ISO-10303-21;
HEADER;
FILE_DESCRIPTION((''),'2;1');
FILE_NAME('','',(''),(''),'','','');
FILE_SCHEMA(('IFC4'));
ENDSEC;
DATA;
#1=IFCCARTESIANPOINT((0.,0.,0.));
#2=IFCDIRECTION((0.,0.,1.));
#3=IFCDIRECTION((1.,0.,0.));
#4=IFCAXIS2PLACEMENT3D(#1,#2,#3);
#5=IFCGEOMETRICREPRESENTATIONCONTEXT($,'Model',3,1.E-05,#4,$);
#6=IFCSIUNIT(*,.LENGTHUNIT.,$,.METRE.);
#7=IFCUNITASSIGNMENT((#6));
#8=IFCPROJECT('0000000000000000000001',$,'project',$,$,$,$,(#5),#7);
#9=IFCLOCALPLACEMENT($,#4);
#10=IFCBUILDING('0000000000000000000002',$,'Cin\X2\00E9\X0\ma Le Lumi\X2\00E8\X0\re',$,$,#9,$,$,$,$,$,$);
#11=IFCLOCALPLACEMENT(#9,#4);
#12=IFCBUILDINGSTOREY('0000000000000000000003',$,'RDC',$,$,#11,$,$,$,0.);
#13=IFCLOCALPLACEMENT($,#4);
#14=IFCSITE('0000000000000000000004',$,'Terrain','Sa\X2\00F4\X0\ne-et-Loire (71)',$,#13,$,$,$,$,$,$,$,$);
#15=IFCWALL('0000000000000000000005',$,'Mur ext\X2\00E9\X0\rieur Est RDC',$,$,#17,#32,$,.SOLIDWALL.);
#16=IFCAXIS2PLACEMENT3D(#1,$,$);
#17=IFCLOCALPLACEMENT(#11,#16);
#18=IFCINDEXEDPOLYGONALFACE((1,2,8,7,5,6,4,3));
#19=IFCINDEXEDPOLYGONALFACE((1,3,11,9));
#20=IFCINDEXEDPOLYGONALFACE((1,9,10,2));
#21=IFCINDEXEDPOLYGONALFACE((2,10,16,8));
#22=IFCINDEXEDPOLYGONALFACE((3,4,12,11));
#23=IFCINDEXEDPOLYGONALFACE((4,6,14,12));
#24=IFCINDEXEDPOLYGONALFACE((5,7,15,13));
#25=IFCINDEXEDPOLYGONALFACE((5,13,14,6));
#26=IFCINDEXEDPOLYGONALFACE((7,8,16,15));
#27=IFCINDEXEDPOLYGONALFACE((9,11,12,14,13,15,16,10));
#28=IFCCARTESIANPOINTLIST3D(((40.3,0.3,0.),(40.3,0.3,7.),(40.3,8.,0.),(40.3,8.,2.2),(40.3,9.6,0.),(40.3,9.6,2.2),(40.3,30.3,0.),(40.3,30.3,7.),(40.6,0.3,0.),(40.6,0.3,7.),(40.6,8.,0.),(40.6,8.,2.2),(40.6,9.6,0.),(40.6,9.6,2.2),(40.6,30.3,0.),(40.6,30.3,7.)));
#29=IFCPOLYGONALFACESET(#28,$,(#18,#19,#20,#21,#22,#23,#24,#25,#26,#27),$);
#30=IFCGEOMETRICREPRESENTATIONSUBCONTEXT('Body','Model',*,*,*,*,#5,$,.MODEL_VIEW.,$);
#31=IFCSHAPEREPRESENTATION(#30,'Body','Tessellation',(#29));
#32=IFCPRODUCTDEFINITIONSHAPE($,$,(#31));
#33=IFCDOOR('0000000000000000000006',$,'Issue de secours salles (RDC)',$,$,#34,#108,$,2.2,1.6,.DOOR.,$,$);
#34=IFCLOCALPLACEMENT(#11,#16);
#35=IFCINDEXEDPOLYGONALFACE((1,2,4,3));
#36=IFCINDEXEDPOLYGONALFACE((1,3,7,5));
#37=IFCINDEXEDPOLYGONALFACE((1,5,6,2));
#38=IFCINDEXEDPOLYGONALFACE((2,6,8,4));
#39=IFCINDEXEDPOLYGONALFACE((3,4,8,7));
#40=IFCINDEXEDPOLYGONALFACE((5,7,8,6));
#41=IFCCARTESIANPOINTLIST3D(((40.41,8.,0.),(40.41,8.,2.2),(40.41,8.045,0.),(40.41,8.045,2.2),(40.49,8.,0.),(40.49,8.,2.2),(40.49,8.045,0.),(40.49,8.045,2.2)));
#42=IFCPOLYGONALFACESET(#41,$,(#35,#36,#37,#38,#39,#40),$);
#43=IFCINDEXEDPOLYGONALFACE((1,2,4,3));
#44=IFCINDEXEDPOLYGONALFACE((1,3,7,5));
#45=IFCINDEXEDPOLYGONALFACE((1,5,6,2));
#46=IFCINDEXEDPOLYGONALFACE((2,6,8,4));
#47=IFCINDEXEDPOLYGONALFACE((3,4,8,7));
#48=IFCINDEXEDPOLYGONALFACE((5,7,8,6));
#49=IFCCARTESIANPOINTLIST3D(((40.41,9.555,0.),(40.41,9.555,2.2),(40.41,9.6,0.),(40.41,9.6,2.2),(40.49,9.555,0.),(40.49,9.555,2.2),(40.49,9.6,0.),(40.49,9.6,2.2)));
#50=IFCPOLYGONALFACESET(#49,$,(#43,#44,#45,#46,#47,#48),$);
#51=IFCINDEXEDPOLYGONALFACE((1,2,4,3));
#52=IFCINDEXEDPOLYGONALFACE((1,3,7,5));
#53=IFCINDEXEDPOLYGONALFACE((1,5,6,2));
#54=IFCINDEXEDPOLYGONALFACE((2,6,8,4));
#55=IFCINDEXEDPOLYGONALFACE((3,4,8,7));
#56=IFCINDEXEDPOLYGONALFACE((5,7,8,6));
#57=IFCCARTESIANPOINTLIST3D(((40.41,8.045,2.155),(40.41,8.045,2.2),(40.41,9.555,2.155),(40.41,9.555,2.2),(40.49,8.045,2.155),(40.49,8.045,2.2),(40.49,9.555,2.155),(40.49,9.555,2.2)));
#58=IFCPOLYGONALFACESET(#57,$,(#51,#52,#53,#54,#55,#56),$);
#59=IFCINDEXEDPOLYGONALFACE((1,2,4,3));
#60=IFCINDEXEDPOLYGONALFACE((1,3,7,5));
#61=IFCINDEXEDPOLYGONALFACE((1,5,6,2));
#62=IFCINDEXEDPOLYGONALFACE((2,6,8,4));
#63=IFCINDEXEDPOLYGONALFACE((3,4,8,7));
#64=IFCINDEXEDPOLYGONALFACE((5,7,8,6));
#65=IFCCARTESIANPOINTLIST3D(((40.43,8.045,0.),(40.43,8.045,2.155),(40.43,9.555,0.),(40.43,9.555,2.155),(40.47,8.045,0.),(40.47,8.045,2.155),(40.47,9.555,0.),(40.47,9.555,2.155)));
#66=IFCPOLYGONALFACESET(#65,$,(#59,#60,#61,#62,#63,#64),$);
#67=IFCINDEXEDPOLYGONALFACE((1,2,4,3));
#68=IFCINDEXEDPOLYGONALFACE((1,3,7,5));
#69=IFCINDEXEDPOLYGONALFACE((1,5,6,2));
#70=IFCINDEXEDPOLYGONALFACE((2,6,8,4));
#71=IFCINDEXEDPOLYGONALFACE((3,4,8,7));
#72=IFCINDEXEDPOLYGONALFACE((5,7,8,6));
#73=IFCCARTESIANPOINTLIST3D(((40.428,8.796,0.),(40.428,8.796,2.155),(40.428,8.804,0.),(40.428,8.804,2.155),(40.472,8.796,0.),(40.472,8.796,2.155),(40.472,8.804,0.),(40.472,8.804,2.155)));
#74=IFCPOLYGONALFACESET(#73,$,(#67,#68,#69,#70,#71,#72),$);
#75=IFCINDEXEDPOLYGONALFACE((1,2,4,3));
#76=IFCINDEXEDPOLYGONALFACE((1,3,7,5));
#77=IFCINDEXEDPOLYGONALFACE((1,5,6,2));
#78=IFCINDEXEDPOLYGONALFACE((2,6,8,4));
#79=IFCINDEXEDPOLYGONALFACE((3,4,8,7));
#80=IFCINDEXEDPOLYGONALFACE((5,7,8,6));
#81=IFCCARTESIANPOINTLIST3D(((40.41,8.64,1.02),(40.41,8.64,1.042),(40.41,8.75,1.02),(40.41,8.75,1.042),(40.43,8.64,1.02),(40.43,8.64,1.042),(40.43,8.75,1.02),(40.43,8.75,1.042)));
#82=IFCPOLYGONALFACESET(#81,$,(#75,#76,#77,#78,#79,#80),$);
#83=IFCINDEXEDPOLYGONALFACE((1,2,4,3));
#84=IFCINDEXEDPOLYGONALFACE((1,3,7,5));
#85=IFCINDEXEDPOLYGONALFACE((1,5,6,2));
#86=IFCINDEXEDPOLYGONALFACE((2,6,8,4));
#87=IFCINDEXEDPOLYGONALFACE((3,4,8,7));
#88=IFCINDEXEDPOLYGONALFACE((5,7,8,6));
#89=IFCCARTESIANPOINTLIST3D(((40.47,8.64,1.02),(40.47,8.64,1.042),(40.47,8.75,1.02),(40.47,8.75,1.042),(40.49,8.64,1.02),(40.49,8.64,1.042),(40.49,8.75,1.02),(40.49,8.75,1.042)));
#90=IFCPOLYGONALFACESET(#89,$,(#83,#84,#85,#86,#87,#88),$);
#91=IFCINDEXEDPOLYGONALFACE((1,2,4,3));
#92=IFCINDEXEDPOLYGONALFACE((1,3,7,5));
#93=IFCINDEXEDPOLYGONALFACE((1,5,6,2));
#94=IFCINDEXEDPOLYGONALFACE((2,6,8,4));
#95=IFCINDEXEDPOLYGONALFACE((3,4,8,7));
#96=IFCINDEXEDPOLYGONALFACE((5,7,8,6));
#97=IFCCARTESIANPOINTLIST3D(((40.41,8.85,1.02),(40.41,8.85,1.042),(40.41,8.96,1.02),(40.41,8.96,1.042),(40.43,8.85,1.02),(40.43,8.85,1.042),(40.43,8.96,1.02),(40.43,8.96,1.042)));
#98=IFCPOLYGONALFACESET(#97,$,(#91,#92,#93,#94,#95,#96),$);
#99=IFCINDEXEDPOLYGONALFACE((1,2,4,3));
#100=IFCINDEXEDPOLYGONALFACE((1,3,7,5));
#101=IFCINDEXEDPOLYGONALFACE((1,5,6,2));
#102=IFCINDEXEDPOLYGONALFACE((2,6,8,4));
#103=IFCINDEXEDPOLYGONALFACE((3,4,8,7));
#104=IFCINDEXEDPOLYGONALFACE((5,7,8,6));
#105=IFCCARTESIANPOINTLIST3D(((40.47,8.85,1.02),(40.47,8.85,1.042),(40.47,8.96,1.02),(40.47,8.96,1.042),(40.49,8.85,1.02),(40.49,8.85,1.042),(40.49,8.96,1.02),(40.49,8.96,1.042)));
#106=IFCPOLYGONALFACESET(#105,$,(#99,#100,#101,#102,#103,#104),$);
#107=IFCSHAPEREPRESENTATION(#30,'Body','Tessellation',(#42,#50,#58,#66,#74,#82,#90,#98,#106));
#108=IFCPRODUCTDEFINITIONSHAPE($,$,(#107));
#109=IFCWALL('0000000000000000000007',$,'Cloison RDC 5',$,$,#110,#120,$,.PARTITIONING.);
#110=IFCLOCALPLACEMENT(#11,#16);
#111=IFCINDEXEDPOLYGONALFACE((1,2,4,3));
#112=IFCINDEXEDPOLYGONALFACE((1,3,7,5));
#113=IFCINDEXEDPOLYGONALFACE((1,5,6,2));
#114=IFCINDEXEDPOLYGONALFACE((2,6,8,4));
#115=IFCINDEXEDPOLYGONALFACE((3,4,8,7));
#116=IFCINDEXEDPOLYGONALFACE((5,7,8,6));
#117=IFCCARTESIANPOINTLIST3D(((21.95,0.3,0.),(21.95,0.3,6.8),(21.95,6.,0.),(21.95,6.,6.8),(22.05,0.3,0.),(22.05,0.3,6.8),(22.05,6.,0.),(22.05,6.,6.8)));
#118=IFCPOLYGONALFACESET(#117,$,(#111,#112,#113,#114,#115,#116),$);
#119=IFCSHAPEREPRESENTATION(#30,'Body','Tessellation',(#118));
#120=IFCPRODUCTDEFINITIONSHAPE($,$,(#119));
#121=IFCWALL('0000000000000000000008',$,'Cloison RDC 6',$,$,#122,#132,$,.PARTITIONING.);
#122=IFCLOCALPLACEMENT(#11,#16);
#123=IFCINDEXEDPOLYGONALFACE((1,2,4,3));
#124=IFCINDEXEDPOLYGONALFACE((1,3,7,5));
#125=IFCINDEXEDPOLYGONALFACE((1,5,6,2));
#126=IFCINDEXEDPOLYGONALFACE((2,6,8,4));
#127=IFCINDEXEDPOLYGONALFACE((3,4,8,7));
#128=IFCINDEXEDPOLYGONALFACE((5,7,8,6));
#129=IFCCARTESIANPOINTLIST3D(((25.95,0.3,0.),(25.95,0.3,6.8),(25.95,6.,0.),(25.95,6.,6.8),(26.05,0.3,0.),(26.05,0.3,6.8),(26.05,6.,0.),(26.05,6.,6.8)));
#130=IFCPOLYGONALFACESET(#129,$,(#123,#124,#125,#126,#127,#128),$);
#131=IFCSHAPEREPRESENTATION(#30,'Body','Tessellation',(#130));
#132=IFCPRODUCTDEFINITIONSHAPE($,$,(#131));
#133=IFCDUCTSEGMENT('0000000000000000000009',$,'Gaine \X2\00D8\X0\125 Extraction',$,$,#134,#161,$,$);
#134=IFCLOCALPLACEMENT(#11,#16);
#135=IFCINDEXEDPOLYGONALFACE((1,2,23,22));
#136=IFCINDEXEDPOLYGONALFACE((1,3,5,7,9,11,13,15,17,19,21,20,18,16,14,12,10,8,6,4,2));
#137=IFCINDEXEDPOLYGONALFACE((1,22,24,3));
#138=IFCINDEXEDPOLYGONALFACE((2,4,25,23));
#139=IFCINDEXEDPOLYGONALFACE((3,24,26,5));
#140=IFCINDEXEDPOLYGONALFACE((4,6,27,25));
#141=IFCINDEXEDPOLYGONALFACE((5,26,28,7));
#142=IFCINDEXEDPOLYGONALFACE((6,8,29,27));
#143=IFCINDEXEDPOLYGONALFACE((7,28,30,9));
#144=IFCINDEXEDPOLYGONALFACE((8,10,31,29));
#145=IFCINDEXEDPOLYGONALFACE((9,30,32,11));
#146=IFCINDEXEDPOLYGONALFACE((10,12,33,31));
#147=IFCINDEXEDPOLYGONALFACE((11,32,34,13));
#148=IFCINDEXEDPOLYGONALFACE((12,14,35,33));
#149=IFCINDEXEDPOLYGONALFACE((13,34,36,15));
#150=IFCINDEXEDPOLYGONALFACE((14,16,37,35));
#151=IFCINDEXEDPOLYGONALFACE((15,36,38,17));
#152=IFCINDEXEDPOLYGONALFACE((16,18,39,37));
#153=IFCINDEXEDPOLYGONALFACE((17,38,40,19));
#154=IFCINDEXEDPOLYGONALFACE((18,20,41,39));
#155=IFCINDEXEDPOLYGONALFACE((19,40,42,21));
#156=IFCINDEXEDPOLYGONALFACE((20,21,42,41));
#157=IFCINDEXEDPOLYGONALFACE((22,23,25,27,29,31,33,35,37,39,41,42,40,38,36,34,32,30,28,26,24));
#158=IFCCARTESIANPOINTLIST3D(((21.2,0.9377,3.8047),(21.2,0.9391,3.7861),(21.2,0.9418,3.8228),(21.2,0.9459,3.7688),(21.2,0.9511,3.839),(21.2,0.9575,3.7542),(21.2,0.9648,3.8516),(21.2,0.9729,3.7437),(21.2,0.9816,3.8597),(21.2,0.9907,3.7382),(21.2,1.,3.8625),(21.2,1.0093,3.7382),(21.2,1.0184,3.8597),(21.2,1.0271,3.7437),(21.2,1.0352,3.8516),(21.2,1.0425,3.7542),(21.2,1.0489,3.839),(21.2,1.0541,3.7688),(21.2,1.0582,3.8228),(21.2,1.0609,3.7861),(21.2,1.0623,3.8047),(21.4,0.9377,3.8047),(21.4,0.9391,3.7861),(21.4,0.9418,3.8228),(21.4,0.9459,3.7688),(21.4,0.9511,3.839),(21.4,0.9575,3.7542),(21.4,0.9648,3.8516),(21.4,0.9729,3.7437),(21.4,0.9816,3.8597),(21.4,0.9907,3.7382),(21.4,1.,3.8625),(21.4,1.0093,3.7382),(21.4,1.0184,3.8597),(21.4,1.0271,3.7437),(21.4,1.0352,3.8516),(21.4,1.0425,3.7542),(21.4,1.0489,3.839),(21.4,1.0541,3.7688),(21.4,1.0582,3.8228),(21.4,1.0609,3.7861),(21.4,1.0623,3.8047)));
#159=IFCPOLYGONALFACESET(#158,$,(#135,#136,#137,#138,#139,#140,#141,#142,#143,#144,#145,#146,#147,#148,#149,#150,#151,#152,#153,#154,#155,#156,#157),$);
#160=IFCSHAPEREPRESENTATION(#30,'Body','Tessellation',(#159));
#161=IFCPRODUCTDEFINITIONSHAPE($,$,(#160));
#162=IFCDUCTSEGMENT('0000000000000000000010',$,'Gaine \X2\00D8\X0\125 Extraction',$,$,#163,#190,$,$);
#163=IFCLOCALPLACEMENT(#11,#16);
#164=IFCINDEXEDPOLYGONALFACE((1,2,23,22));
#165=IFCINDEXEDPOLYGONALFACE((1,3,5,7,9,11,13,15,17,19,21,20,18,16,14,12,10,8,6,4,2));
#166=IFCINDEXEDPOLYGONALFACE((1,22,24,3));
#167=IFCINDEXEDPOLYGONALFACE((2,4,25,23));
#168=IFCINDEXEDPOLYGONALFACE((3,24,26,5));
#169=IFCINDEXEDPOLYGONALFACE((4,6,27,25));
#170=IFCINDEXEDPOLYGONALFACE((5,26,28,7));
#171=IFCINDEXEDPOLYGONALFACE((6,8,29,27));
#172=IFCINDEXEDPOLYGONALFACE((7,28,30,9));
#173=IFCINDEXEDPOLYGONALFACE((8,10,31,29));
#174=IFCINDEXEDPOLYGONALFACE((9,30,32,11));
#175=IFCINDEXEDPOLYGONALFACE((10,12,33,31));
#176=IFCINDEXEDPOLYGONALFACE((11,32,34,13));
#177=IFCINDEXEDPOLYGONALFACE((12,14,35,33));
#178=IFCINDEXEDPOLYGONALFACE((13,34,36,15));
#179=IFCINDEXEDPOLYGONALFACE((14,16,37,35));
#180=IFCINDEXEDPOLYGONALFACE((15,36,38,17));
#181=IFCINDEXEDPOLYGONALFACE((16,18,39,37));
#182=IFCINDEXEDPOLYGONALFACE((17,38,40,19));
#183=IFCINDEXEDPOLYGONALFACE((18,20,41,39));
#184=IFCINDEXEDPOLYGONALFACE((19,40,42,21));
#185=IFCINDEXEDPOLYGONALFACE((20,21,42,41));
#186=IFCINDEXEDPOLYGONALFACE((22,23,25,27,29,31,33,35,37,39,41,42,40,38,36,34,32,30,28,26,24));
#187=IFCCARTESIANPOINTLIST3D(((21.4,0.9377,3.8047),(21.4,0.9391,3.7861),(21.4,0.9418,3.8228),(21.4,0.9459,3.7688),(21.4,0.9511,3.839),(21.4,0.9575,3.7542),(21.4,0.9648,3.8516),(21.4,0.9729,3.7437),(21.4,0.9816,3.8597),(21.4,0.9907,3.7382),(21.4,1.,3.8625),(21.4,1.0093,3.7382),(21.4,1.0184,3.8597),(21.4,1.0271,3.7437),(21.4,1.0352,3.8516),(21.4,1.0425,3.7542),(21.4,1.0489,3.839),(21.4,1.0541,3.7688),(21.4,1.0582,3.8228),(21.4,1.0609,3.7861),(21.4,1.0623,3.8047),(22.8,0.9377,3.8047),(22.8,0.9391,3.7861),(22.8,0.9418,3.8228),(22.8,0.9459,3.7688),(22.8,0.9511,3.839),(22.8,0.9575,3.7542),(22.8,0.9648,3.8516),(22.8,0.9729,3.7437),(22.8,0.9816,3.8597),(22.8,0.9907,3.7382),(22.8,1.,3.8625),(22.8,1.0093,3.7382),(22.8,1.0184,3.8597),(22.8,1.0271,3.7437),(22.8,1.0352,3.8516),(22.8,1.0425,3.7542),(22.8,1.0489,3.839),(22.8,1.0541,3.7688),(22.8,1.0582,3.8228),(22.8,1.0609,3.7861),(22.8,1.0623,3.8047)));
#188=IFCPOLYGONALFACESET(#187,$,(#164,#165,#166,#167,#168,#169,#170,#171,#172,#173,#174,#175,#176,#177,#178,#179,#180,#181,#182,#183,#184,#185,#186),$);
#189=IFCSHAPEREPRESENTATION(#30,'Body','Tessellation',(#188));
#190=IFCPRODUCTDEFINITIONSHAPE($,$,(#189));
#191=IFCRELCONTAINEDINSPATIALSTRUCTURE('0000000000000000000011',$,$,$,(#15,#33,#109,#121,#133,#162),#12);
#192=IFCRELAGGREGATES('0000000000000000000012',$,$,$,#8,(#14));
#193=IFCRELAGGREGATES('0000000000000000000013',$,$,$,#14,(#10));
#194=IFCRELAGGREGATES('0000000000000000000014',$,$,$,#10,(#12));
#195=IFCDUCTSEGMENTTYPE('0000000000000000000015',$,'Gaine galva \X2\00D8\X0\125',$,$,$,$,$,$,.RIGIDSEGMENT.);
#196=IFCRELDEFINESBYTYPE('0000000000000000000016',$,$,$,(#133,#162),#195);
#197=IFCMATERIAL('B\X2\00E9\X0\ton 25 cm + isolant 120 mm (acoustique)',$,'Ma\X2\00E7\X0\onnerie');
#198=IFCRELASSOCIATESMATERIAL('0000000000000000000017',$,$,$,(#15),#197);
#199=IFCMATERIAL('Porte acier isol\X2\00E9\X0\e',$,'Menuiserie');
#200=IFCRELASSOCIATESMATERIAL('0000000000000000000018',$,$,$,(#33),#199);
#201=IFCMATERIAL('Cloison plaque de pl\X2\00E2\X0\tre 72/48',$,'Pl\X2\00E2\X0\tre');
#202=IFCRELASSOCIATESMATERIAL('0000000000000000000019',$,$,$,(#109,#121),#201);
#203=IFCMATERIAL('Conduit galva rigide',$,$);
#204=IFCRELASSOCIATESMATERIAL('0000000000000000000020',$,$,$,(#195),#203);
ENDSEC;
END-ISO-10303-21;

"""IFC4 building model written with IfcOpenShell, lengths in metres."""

from ifc_helpers import new_model, si_unit, frame, frame_2d, origin_with_axes, place, context, subcontext, project, spatial, rectangle, circle, extrude, material, type_object, element, fill, save


model = new_model("IFC4")

# Units and contexts
model_context = context("Model", 3, precision=1e-05, world=origin_with_axes())
body_context = subcontext(model_context, "Body", "Model", "MODEL_VIEW")
ifc_project = project(units=[si_unit("LENGTHUNIT", "METRE")], contexts=[model_context])

# Site, building, storey
site_placement = place(None, origin_with_axes())
site = spatial("IfcSite", under=ifc_project, at=site_placement, Name="Terrain", Description="Saône-et-Loire (71)")
building_placement = place(None, origin_with_axes())
building = spatial("IfcBuilding", under=site, at=building_placement, Name="Cinéma Le Lumière")
storey_placement = place(building_placement, origin_with_axes())
storey = spatial("IfcBuildingStorey", under=building, at=storey_placement, Name="RDC", Elevation=0.0)

# Wall, opening, door
ifc_material_1 = material(Name="Béton 25 cm + isolant 120 mm (acoustique)", Category="Maçonnerie")
wall_placement = place(storey_placement, frame((40.3, 0.3, 0.0), z_axis=(0.0, 0.0, 1.0), x_axis=(1.0, 0.0, 0.0)))
wall = element("IfcWall", 1, at=wall_placement, inside=storey, material=ifc_material_1, Name="Mur extérieur Est RDC", PredefinedType="SOLIDWALL", context=body_context, shape_type="SweptSolid", body=[
    extrude(rectangle(XDim=0.3, YDim=30.0, at=frame_2d((0.15, 15.0))), origin_with_axes(), (0.0, 0.0, 1.0), 7.0),
])
opening_placement = place(storey_placement, frame((40.25, 8.0, 0.0), z_axis=(0.0, 0.0, 1.0), x_axis=(1.0, 0.0, 0.0)))
opening = element("IfcOpeningElement", 2, at=opening_placement, cuts=wall, context=body_context, shape_type="SweptSolid", body=[
    extrude(rectangle(XDim=0.4, YDim=1.6, at=frame_2d((0.2, 0.8))), origin_with_axes(), (0.0, 0.0, 1.0), 2.2),
])
ifc_material_2 = material(Name="Porte acier isolée", Category="Menuiserie")
door_placement = place(storey_placement, frame((40.41, 8.0, 0.0), z_axis=(0.0, 0.0, 1.0), x_axis=(1.0, 0.0, 0.0)))
door = element("IfcDoor", 3, at=door_placement, inside=storey, material=ifc_material_2, Name="Issue de secours salles (RDC)", OverallHeight=2.2, OverallWidth=1.6, PredefinedType="DOOR", context=body_context, shape_type="SweptSolid", body=[
    extrude(rectangle(XDim=0.08, YDim=0.045, at=frame_2d((0.04, 0.0225))), origin_with_axes(), (0.0, 0.0, 1.0), 2.2),
    extrude(rectangle(XDim=0.08, YDim=0.045, at=frame_2d((0.04, 0.0225))), frame((0.0, 1.555, 0.0), z_axis=(0.0, 0.0, 1.0), x_axis=(1.0, 0.0, 0.0)), (0.0, 0.0, 1.0), 2.2),
    extrude(rectangle(XDim=0.08, YDim=1.51, at=frame_2d((0.04, 0.755))), frame((0.0, 0.045, 2.155), z_axis=(0.0, 0.0, 1.0), x_axis=(1.0, 0.0, 0.0)), (0.0, 0.0, 1.0), 0.045),
    extrude(rectangle(XDim=0.04, YDim=1.51, at=frame_2d((0.02, 0.755))), frame((0.02, 0.045, 0.0), z_axis=(0.0, 0.0, 1.0), x_axis=(1.0, 0.0, 0.0)), (0.0, 0.0, 1.0), 2.155),
    extrude(rectangle(XDim=0.044, YDim=0.008, at=frame_2d((0.022, 0.004))), frame((0.018, 0.796, 0.0), z_axis=(0.0, 0.0, 1.0), x_axis=(1.0, 0.0, 0.0)), (0.0, 0.0, 1.0), 2.155),
    extrude(rectangle(XDim=0.02, YDim=0.11, at=frame_2d((0.01, 0.055))), frame((0.0, 0.64, 1.02), z_axis=(0.0, 0.0, 1.0), x_axis=(1.0, 0.0, 0.0)), (0.0, 0.0, 1.0), 0.022),
    extrude(rectangle(XDim=0.02, YDim=0.11, at=frame_2d((0.01, 0.055))), frame((0.06, 0.64, 1.02), z_axis=(0.0, 0.0, 1.0), x_axis=(1.0, 0.0, 0.0)), (0.0, 0.0, 1.0), 0.022),
    extrude(rectangle(XDim=0.02, YDim=0.11, at=frame_2d((0.01, 0.055))), frame((0.0, 0.85, 1.02), z_axis=(0.0, 0.0, 1.0), x_axis=(1.0, 0.0, 0.0)), (0.0, 0.0, 1.0), 0.022),
    extrude(rectangle(XDim=0.02, YDim=0.11, at=frame_2d((0.01, 0.055))), frame((0.06, 0.85, 1.02), z_axis=(0.0, 0.0, 1.0), x_axis=(1.0, 0.0, 0.0)), (0.0, 0.0, 1.0), 0.022),
])
fill(opening, door)

# Walls
ifc_material_3 = material(Name="Cloison plaque de plâtre 72/48", Category="Plâtre")
for number, where, z_axis, x_axis, name in (
    (4, (21.95, 0.3, 0.0), (0.0, 0.0, 1.0), (1.0, 0.0, 0.0), "Cloison RDC 5"),
    (5, (25.95, 0.3, 0.0), (0.0, 0.0, 1.0), (1.0, 0.0, 0.0), "Cloison RDC 6"),
):
    element("IfcWall", number, at=place(storey_placement, frame(where, z_axis=z_axis, x_axis=x_axis)), inside=storey, material=ifc_material_3, Name=name, PredefinedType="PARTITIONING", context=body_context, shape_type="SweptSolid", body=[
        extrude(rectangle(XDim=0.1, YDim=5.7, at=frame_2d((0.05, 2.85))), origin_with_axes(), (0.0, 0.0, 1.0), 6.8),
    ])

# Duct segments
ifc_material_4 = material(Name="Conduit galva rigide")
duct_segment_type_1 = type_object("IfcDuctSegmentType", Name="Gaine galva Ø125", PredefinedType="RIGIDSEGMENT", material=ifc_material_4)
duct_segment_1_placement = place(storey_placement, frame((21.2, 1.0, 3.8), z_axis=(1.0, 0.0, 0.0), x_axis=(0.0, 0.0, 1.0)))
element("IfcDuctSegment", 6, at=duct_segment_1_placement, inside=storey, type_object=duct_segment_type_1, Name="Gaine Ø125 Extraction", context=body_context, shape_type="SweptSolid", body=[
    extrude(circle(Radius=0.0625), origin_with_axes(), (0.0, 0.0, 1.0), 0.2),
])
duct_segment_2_placement = place(storey_placement, frame((22.8, 1.0, 3.8), z_axis=(-1.0, 0.0, 0.0), x_axis=(0.0, 0.0, 1.0)))
element("IfcDuctSegment", 7, at=duct_segment_2_placement, inside=storey, type_object=duct_segment_type_1, Name="Gaine Ø125 Extraction", context=body_context, shape_type="SweptSolid", body=[
    extrude(circle(Radius=0.0625), origin_with_axes(), (0.0, 0.0, 1.0), 1.4),
])

save(model, "model.ifc")
